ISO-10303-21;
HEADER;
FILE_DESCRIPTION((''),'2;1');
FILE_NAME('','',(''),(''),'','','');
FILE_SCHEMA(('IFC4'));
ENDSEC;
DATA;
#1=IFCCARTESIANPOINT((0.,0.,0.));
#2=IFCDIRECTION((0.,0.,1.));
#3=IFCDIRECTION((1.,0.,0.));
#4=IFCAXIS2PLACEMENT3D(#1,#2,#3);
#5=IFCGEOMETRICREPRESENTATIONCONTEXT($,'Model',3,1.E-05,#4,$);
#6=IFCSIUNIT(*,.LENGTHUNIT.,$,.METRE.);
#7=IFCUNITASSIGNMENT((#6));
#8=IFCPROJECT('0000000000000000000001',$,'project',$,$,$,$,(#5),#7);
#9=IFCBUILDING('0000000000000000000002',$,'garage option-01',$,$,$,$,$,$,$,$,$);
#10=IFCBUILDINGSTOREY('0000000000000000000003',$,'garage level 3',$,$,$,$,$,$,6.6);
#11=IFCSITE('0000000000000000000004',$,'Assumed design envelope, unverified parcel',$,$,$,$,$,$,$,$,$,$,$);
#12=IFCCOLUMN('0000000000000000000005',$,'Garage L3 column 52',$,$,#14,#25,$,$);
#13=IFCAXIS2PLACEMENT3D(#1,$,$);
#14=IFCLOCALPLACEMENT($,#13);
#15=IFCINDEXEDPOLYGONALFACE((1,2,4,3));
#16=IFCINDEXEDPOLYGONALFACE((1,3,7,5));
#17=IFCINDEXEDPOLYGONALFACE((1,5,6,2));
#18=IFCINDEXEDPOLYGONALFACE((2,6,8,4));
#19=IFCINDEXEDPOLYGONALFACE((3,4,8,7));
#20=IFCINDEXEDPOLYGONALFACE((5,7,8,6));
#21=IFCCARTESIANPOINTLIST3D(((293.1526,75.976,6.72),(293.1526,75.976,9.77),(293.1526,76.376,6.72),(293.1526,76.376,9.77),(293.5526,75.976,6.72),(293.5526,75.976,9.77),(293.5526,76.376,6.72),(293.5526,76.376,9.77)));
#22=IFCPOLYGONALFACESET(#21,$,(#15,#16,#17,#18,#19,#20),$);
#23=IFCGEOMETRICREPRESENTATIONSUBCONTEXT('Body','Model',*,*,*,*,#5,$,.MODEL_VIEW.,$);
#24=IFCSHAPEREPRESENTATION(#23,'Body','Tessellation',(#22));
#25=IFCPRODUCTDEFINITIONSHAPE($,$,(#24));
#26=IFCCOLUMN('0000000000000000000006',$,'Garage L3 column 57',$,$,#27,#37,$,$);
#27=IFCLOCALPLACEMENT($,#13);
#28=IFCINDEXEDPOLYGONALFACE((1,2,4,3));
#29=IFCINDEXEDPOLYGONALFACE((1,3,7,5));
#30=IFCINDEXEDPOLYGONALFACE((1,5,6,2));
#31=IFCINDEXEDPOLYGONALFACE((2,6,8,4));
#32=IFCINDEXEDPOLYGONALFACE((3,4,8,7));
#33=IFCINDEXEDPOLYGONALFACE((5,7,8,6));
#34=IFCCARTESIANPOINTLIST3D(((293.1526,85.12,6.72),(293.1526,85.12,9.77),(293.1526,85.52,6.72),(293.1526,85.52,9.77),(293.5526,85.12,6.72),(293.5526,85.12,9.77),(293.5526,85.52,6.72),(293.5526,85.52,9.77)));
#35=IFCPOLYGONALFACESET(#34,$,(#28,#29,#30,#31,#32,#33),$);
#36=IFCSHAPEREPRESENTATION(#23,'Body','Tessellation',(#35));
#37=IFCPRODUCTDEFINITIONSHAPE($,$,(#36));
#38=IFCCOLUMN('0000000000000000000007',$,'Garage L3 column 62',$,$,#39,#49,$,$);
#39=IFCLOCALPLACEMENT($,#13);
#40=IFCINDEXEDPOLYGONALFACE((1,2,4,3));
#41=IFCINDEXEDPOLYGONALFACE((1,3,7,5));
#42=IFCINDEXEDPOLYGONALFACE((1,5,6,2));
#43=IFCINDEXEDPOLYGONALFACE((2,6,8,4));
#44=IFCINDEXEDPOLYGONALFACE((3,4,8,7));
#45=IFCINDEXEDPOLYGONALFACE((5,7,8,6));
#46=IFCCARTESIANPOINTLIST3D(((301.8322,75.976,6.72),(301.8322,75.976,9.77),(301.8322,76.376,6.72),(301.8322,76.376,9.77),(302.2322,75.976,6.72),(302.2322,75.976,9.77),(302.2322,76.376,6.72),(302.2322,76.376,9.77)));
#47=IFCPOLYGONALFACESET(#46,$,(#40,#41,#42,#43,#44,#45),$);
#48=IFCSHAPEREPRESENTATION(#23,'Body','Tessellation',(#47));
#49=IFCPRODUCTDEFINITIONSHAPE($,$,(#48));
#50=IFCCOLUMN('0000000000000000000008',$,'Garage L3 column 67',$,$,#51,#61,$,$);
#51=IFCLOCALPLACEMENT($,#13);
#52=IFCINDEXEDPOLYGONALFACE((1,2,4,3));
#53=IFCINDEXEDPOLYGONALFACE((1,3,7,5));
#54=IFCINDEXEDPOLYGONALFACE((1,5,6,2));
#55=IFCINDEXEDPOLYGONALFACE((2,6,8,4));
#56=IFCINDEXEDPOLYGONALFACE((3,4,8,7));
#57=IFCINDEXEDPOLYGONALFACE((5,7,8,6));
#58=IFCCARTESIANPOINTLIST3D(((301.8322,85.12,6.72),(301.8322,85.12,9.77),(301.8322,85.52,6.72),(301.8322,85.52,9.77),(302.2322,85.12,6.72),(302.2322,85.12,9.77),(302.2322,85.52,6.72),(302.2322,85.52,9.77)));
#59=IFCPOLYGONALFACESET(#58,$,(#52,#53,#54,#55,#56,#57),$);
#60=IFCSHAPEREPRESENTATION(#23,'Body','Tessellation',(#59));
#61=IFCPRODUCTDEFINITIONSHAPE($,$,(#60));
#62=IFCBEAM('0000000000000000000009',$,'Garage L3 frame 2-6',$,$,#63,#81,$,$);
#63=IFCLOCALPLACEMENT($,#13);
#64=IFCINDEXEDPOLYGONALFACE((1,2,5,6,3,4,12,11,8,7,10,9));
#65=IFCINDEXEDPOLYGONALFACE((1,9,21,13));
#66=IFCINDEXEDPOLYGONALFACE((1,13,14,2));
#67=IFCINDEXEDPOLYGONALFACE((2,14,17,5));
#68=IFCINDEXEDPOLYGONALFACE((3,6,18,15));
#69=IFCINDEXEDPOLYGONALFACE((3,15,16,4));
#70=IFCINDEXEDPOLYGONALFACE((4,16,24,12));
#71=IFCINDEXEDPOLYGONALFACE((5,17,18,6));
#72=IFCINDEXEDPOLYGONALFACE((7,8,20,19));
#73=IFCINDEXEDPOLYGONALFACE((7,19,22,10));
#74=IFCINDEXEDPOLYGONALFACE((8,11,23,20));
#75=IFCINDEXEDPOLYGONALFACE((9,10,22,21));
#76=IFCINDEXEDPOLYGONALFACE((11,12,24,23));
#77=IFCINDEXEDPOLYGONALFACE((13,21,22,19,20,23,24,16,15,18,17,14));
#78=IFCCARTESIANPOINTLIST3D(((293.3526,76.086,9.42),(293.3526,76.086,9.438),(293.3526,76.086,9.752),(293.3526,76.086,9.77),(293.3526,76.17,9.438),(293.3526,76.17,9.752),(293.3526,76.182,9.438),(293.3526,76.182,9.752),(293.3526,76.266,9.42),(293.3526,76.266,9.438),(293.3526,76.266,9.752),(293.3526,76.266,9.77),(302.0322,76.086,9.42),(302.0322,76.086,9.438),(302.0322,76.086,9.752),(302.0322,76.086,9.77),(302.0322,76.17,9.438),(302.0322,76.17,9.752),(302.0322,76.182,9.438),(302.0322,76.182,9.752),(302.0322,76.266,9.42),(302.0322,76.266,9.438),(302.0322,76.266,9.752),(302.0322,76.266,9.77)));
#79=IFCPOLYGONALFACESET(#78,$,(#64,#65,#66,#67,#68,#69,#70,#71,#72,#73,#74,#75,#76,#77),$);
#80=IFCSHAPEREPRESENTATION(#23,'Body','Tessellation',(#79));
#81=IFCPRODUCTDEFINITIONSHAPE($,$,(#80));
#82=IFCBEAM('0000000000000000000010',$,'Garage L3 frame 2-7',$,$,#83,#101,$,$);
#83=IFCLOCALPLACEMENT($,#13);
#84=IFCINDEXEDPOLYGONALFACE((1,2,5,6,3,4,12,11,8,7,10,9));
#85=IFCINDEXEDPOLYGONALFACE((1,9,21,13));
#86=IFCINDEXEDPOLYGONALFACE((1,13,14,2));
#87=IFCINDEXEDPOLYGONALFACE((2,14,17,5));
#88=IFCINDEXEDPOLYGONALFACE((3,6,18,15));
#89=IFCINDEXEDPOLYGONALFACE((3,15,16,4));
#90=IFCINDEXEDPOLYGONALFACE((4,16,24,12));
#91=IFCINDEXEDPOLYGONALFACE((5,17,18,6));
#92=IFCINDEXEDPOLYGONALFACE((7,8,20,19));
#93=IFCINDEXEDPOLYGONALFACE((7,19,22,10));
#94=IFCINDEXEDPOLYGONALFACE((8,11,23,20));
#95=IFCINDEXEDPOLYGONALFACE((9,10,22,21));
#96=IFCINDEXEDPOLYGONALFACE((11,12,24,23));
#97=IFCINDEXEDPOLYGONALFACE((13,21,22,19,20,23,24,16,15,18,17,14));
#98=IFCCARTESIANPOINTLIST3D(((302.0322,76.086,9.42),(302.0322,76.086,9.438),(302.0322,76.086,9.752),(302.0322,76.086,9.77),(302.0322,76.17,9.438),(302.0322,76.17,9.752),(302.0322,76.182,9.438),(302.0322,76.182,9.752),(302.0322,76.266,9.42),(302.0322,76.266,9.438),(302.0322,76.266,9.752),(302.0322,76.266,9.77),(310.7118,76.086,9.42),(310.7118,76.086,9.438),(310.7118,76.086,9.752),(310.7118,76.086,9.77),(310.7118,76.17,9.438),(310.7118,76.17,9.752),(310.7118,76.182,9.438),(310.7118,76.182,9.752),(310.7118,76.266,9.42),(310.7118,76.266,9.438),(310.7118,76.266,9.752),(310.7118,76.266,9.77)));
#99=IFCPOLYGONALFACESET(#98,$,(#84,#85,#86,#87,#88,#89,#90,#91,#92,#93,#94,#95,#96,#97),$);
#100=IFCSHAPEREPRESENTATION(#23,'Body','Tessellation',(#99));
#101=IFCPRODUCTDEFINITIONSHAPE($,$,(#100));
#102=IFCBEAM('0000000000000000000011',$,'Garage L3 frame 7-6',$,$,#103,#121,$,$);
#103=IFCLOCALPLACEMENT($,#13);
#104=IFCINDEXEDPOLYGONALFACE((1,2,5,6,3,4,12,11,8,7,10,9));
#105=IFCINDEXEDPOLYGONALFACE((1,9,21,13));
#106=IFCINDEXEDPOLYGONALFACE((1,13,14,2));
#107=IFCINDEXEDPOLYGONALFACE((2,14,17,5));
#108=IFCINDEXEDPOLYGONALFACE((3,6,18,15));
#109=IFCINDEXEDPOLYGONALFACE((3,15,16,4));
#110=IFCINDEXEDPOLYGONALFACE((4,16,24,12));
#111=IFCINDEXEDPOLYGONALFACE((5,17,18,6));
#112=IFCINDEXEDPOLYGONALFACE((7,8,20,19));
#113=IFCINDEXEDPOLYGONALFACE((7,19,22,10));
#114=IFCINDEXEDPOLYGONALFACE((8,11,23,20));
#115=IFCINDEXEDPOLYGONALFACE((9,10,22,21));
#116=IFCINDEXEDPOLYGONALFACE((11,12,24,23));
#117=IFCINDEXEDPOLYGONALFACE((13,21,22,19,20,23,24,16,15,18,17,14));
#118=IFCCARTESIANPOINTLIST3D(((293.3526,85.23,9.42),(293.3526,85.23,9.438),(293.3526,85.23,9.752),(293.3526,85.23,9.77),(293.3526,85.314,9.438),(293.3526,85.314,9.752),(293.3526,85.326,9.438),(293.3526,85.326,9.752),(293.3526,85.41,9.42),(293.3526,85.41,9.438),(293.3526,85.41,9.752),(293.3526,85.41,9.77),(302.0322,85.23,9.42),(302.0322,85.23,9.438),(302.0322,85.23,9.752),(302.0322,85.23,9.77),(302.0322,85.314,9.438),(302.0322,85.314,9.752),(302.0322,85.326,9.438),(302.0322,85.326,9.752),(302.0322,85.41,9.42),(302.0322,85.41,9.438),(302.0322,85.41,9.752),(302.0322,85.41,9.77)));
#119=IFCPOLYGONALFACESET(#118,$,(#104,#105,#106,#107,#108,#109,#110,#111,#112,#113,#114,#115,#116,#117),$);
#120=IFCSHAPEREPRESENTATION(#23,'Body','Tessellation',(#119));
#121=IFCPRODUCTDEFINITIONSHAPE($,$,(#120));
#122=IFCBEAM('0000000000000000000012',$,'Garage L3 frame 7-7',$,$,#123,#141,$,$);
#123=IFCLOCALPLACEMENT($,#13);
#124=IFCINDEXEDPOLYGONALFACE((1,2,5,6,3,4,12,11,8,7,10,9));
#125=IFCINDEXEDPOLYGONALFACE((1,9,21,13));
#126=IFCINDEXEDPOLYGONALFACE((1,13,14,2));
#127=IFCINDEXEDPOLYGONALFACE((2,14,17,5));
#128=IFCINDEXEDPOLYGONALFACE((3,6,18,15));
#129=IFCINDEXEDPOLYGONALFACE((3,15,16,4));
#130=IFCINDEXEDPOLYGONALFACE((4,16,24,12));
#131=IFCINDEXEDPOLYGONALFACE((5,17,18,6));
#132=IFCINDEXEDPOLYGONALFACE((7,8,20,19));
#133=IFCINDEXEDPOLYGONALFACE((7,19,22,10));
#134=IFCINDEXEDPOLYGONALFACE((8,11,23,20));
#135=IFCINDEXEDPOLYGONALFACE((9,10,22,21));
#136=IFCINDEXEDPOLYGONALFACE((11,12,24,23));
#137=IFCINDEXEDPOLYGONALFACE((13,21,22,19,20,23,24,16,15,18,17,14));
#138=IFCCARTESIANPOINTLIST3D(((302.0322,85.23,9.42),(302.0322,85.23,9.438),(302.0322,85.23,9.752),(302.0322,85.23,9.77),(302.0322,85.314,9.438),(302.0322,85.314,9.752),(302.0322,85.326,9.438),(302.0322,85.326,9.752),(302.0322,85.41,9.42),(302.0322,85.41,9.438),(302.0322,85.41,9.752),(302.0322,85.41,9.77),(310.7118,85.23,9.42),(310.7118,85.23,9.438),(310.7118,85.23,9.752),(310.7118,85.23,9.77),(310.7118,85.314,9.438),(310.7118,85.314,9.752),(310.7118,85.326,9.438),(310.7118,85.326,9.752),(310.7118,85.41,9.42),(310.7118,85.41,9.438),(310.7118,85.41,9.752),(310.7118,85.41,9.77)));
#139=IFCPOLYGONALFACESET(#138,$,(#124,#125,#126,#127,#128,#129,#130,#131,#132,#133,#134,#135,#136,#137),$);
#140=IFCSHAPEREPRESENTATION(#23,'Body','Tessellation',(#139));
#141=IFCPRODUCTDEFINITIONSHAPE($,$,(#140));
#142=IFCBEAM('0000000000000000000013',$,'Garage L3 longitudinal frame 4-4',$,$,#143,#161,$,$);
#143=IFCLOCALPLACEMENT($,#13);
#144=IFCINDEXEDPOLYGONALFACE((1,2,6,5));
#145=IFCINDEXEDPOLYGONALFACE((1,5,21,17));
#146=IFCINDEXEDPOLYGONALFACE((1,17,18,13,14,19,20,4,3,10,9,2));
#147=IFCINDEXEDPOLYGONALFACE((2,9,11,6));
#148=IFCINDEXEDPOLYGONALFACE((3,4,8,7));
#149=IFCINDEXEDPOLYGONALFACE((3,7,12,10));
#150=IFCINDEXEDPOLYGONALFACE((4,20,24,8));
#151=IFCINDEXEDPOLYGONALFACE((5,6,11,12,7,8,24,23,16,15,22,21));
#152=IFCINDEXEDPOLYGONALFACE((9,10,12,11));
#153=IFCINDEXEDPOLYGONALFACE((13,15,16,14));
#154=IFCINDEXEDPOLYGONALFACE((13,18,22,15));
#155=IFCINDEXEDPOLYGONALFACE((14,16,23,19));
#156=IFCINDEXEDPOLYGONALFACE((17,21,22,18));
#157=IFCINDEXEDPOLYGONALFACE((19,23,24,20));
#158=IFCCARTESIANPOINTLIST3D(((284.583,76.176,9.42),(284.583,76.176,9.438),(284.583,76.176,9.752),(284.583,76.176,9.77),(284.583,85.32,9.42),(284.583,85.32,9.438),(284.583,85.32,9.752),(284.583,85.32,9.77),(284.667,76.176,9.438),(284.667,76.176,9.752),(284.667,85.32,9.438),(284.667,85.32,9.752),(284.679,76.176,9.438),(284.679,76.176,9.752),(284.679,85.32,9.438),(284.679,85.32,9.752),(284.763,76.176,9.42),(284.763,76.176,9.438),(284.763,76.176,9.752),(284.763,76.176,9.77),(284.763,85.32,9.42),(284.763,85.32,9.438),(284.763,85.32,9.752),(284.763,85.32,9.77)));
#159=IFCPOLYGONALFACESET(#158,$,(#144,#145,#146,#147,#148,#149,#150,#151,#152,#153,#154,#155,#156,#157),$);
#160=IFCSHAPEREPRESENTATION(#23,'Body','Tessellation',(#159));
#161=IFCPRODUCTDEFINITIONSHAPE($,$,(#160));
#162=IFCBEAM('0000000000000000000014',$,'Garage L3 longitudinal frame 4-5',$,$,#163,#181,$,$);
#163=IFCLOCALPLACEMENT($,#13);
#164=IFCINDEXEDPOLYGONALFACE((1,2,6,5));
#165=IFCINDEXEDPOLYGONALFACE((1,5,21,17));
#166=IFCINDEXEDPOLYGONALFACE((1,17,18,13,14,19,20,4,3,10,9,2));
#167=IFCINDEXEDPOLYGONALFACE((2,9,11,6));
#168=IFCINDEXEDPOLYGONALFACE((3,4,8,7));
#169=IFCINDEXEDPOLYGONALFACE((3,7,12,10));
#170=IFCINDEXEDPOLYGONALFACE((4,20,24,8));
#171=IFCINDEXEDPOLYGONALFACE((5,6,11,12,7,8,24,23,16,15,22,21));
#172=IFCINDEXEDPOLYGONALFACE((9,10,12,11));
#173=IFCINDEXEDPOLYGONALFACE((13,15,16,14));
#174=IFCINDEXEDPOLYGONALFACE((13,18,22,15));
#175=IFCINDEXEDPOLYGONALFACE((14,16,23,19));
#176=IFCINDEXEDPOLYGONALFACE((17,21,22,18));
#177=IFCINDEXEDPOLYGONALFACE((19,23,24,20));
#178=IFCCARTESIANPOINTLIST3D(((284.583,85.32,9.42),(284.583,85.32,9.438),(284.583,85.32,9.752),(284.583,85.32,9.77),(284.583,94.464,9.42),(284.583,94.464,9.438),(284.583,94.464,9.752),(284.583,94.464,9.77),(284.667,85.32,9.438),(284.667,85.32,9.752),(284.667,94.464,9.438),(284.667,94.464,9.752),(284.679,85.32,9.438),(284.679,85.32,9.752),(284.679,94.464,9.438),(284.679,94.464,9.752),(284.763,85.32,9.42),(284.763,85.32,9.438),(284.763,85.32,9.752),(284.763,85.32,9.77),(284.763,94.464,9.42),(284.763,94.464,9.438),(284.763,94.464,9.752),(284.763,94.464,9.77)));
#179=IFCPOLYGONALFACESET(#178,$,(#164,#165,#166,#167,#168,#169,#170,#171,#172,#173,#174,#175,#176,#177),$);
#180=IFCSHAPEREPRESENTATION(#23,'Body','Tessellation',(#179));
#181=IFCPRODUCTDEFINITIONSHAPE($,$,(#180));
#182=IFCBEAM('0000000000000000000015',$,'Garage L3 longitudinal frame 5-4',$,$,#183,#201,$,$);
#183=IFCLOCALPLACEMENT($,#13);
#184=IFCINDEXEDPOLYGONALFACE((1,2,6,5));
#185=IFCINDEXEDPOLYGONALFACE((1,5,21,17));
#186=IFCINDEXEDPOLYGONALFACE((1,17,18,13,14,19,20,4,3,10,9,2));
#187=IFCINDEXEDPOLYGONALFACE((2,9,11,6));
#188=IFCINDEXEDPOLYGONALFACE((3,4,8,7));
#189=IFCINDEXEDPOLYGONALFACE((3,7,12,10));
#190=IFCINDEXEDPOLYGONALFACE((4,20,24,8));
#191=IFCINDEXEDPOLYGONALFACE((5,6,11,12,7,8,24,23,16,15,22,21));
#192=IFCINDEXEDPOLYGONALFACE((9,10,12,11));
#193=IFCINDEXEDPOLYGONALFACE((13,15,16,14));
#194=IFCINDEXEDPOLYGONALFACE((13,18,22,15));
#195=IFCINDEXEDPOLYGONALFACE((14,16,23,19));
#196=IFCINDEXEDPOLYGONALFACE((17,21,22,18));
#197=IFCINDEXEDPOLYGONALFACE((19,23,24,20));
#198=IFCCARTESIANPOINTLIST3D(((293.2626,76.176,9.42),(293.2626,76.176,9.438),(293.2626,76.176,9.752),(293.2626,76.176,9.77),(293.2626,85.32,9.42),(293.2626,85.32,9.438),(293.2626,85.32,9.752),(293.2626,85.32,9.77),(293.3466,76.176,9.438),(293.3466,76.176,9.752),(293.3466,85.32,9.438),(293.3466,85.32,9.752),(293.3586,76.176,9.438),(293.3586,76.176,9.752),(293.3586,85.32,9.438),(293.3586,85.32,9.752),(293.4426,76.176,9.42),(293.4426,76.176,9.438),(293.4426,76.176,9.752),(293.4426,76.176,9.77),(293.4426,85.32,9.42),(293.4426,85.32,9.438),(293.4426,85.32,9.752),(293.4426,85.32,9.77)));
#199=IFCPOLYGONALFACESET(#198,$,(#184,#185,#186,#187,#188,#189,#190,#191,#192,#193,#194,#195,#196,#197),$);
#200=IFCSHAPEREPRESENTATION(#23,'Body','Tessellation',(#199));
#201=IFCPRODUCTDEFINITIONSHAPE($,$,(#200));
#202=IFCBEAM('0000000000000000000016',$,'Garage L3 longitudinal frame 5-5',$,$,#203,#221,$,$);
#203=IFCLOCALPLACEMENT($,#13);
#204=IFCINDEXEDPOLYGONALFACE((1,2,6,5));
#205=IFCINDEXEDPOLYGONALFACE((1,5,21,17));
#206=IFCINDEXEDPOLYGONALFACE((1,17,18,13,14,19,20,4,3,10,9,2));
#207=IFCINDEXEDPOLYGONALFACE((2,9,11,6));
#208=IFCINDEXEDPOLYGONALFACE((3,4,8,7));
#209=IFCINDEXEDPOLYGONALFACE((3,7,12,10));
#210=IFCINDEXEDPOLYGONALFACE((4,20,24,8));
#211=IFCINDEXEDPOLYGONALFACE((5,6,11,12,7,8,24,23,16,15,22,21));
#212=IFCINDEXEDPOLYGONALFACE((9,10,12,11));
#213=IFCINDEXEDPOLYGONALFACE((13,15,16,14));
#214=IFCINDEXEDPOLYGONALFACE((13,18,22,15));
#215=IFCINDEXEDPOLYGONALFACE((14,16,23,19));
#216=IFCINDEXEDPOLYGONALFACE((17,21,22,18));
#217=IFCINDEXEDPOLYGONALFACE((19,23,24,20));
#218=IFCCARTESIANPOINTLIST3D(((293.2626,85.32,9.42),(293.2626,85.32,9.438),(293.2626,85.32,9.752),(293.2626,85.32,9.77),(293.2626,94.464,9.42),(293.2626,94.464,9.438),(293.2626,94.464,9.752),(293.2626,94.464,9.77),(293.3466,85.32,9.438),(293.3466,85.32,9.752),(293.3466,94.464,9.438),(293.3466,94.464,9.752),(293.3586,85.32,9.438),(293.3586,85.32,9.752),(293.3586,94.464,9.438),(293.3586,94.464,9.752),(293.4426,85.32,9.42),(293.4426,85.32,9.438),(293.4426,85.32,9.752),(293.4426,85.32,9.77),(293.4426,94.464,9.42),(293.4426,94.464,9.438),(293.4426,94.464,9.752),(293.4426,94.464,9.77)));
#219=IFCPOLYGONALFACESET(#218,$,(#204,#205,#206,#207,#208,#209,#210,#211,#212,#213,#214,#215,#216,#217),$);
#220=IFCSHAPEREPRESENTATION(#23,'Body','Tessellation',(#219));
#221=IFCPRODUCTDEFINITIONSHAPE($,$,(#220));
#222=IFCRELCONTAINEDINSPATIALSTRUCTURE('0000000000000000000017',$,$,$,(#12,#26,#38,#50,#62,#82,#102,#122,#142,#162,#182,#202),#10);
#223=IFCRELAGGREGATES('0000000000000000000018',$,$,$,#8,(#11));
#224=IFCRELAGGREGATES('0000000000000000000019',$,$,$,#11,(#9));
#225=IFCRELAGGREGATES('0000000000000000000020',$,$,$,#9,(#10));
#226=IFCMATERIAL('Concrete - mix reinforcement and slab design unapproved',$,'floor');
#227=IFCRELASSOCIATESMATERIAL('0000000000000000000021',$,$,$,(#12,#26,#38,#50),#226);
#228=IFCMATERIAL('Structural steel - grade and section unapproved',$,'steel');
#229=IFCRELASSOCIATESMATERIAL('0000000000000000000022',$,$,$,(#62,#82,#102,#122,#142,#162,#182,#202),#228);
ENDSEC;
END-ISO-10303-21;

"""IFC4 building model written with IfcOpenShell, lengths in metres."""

from ifc_helpers import new_model, si_unit, frame, origin_with_axes, place, context, subcontext, project, spatial, rectangle, i_section, extrude, material, element, save


model = new_model("IFC4")

# Units and contexts
model_context = context("Model", 3, precision=1e-05, world=origin_with_axes())
body_context = subcontext(model_context, "Body", "Model", "MODEL_VIEW")
ifc_project = project(units=[si_unit("LENGTHUNIT", "METRE")], contexts=[model_context])

# Site, building, storey
site = spatial("IfcSite", under=ifc_project, Name="Assumed design envelope, unverified parcel")
building = spatial("IfcBuilding", under=site, Name="garage option-01")
storey = spatial("IfcBuildingStorey", under=building, Name="garage level 3", Elevation=6.6)

# Columns
ifc_material_1 = material(Name="Concrete - mix reinforcement and slab design unapproved", Category="floor")
for number, where, z_axis, x_axis, name in (
    (1, (293.3526, 76.176, 6.72), (0.0, 0.0, 1.0), (1.0, 0.0, 0.0), "Garage L3 column 52"),
    (2, (293.3526, 85.32, 6.72), (0.0, 0.0, 1.0), (1.0, 0.0, 0.0), "Garage L3 column 57"),
    (3, (302.0322, 76.176, 6.72), (0.0, 0.0, 1.0), (1.0, 0.0, 0.0), "Garage L3 column 62"),
    (4, (302.0322, 85.32, 6.72), (0.0, 0.0, 1.0), (1.0, 0.0, 0.0), "Garage L3 column 67"),
):
    element("IfcColumn", number, at=place(None, frame(where, z_axis=z_axis, x_axis=x_axis)), inside=storey, material=ifc_material_1, Name=name, context=body_context, shape_type="SweptSolid", body=[
        extrude(rectangle(XDim=0.4, YDim=0.4), origin_with_axes(), (0.0, 0.0, 1.0), 3.05),
    ])

# Beams
ifc_material_2 = material(Name="Structural steel - grade and section unapproved", Category="steel")
for number, where, z_axis, x_axis, name in (
    (5, (293.3526, 76.176, 9.595), (1.0, 0.0, 0.0), (0.0, 1.0, 0.0), "Garage L3 frame 2-6"),
    (6, (302.0322, 76.176, 9.595), (1.0, 0.0, 0.0), (0.0, 1.0, 0.0), "Garage L3 frame 2-7"),
    (7, (293.3526, 85.32, 9.595), (1.0, 0.0, 0.0), (0.0, 1.0, 0.0), "Garage L3 frame 7-6"),
    (8, (302.0322, 85.32, 9.595), (1.0, 0.0, 0.0), (0.0, 1.0, 0.0), "Garage L3 frame 7-7"),
):
    element("IfcBeam", number, at=place(None, frame(where, z_axis=z_axis, x_axis=x_axis)), inside=storey, material=ifc_material_2, Name=name, context=body_context, shape_type="SweptSolid", body=[
        extrude(i_section(OverallWidth=0.18, OverallDepth=0.35, WebThickness=0.012, FlangeThickness=0.018, FilletRadius=0.0), origin_with_axes(), (0.0, 0.0, 1.0), 8.6796),
    ])
for number, where, z_axis, x_axis, name in (
    (9, (284.673, 76.176, 9.595), (0.0, 1.0, 0.0), (-1.0, 0.0, 0.0), "Garage L3 longitudinal frame 4-4"),
    (10, (284.673, 85.32, 9.595), (0.0, 1.0, 0.0), (-1.0, 0.0, 0.0), "Garage L3 longitudinal frame 4-5"),
    (11, (293.3526, 76.176, 9.595), (0.0, 1.0, 0.0), (-1.0, 0.0, 0.0), "Garage L3 longitudinal frame 5-4"),
    (12, (293.3526, 85.32, 9.595), (0.0, 1.0, 0.0), (-1.0, 0.0, 0.0), "Garage L3 longitudinal frame 5-5"),
):
    element("IfcBeam", number, at=place(None, frame(where, z_axis=z_axis, x_axis=x_axis)), inside=storey, material=ifc_material_2, Name=name, context=body_context, shape_type="SweptSolid", body=[
        extrude(i_section(OverallWidth=0.18, OverallDepth=0.35, WebThickness=0.012, FlangeThickness=0.018, FilletRadius=0.0), origin_with_axes(), (0.0, 0.0, 1.0), 9.144),
    ])

save(model, "model.ifc")
